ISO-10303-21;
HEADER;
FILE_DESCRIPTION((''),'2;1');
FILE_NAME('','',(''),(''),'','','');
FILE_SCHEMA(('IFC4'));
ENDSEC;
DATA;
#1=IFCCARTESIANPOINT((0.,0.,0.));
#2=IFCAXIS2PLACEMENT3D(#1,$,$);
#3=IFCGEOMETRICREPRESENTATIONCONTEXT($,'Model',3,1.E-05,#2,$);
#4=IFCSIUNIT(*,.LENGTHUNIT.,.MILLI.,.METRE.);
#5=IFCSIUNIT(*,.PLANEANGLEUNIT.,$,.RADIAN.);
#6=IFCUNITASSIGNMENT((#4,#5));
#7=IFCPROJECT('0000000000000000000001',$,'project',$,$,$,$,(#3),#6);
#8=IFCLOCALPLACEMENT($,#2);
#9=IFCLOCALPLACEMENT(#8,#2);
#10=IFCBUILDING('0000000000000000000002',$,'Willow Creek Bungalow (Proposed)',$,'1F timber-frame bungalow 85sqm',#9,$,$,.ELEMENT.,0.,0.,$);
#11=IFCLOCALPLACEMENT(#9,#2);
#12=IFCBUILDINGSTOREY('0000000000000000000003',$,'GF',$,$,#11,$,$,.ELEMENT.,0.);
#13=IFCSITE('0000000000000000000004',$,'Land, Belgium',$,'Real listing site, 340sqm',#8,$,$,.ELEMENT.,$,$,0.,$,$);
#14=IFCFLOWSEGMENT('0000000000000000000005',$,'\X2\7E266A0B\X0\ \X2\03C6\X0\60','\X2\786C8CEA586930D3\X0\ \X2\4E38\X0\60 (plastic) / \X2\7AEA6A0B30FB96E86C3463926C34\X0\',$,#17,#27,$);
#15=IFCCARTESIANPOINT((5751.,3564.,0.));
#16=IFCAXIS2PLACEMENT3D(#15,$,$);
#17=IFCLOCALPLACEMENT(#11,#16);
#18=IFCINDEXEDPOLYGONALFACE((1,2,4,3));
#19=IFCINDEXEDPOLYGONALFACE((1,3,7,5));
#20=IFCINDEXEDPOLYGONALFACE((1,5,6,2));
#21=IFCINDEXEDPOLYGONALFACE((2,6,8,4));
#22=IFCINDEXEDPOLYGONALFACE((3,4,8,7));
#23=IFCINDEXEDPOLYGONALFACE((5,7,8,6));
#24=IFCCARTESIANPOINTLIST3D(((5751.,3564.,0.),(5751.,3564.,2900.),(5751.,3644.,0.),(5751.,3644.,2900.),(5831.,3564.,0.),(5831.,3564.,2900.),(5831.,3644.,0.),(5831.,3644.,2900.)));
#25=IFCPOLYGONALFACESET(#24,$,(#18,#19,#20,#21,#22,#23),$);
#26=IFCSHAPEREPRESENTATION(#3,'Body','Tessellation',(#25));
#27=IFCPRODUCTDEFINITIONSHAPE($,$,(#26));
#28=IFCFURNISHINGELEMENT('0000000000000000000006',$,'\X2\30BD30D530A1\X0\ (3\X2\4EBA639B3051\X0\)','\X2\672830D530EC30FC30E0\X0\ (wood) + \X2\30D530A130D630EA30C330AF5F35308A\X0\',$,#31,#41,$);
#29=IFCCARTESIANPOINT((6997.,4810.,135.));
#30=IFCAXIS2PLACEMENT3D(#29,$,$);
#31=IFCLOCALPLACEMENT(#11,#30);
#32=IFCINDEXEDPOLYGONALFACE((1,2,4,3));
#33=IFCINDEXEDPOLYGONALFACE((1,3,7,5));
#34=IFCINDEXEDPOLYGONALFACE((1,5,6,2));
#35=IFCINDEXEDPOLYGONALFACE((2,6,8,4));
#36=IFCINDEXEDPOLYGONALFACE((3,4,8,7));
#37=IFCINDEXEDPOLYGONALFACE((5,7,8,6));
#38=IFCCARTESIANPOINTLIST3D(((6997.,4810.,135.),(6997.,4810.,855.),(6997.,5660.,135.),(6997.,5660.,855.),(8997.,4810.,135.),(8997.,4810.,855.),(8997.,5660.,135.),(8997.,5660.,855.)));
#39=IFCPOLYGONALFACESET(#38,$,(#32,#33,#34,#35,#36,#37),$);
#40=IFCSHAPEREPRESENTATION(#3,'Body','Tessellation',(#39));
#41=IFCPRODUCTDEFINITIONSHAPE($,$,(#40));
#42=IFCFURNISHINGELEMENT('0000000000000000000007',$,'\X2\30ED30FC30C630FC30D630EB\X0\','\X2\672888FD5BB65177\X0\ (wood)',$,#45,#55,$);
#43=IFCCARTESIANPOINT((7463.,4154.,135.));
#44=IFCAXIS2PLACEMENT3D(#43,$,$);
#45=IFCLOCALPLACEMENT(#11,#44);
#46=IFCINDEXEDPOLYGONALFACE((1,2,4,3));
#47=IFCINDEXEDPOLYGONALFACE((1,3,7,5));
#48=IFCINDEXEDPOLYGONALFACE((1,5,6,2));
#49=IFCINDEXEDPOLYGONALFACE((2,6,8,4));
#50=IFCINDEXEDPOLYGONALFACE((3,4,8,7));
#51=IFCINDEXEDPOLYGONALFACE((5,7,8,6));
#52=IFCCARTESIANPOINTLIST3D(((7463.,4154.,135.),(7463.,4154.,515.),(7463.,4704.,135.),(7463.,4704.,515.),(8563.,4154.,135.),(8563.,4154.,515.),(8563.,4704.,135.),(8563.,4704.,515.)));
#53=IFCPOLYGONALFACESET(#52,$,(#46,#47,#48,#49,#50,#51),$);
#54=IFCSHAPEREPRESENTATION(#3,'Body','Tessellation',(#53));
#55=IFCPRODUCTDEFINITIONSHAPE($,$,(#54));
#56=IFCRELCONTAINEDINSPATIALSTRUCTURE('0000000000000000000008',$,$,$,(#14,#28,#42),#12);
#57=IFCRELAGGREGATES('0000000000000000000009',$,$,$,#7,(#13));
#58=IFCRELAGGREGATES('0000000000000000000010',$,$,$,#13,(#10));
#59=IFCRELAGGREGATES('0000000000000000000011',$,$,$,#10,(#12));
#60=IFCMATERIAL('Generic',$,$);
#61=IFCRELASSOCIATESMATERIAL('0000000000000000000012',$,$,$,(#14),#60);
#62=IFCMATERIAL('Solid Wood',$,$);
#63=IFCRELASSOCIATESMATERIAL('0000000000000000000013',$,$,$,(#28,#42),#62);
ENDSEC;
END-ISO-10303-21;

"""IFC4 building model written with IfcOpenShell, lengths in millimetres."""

from ifc_helpers import new_model, si_unit, frame, frame_2d, origin, place, context, project, spatial, rectangle, extrude, material, element, save


model = new_model("IFC4")

# Units and contexts
model_context = context("Model", 3, precision=1e-05, world=origin())
ifc_project = project(units=[si_unit("LENGTHUNIT", "METRE", prefix="MILLI"), si_unit("PLANEANGLEUNIT", "RADIAN")], contexts=[model_context])

# Site, building, storey
site_placement = place(None, origin())
site = spatial("IfcSite", under=ifc_project, at=site_placement, Name="Land, Belgium", ObjectType="Real listing site, 340sqm", CompositionType="ELEMENT", RefElevation=0.0)
building_placement = place(site_placement, origin())
building = spatial("IfcBuilding", under=site, at=building_placement, Name="Willow Creek Bungalow (Proposed)", ObjectType="1F timber-frame bungalow 85sqm", CompositionType="ELEMENT", ElevationOfRefHeight=0.0, ElevationOfTerrain=0.0)
storey_placement = place(building_placement, origin())
storey = spatial("IfcBuildingStorey", under=building, at=storey_placement, Name="GF", CompositionType="ELEMENT", Elevation=0.0)

# Shared definitions
ifc_material_1 = material(Name="Solid Wood")

# Shared definitions
ifc_material_2 = material(Name="Generic")

# Flow segment
flow_segment_1_placement = place(storey_placement, frame((5751.0, 3564.0, 0.0)))
element("IfcFlowSegment", 1, at=flow_segment_1_placement, inside=storey, material=ifc_material_2, Name="縦樋 φ60", Description="硬質塩ビ 丸60 (plastic) / 竪樋・雨水排水", context=model_context, shape_type="SweptSolid", body=[
    extrude(rectangle(XDim=80.0, YDim=80.0, at=frame_2d((40.0, 40.0))), frame((5751.0, 3564.0, 0.0)), (0.0, 0.0, 1.0), 2900.0),
])

# Furnishing elements
furnishing_1_placement = place(storey_placement, frame((6997.0, 4810.0, 135.0)))
element("IfcFurnishingElement", 2, at=furnishing_1_placement, inside=storey, material=ifc_material_1, Name="ソファ (3人掛け)", Description="木フレーム (wood) + ファブリック張り", context=model_context, shape_type="SweptSolid", body=[
    extrude(rectangle(XDim=2000.0, YDim=850.0, at=frame_2d((1000.0, 425.0))), frame((6997.0, 4810.0, 135.0)), (0.0, 0.0, 1.0), 720.0),
])
furnishing_2_placement = place(storey_placement, frame((7463.0, 4154.0, 135.0)))
element("IfcFurnishingElement", 3, at=furnishing_2_placement, inside=storey, material=ifc_material_1, Name="ローテーブル", Description="木製家具 (wood)", context=model_context, shape_type="SweptSolid", body=[
    extrude(rectangle(XDim=1100.0, YDim=550.0, at=frame_2d((550.0, 275.0))), frame((7463.0, 4154.0, 135.0)), (0.0, 0.0, 1.0), 380.0),
])

save(model, "model.ifc")
